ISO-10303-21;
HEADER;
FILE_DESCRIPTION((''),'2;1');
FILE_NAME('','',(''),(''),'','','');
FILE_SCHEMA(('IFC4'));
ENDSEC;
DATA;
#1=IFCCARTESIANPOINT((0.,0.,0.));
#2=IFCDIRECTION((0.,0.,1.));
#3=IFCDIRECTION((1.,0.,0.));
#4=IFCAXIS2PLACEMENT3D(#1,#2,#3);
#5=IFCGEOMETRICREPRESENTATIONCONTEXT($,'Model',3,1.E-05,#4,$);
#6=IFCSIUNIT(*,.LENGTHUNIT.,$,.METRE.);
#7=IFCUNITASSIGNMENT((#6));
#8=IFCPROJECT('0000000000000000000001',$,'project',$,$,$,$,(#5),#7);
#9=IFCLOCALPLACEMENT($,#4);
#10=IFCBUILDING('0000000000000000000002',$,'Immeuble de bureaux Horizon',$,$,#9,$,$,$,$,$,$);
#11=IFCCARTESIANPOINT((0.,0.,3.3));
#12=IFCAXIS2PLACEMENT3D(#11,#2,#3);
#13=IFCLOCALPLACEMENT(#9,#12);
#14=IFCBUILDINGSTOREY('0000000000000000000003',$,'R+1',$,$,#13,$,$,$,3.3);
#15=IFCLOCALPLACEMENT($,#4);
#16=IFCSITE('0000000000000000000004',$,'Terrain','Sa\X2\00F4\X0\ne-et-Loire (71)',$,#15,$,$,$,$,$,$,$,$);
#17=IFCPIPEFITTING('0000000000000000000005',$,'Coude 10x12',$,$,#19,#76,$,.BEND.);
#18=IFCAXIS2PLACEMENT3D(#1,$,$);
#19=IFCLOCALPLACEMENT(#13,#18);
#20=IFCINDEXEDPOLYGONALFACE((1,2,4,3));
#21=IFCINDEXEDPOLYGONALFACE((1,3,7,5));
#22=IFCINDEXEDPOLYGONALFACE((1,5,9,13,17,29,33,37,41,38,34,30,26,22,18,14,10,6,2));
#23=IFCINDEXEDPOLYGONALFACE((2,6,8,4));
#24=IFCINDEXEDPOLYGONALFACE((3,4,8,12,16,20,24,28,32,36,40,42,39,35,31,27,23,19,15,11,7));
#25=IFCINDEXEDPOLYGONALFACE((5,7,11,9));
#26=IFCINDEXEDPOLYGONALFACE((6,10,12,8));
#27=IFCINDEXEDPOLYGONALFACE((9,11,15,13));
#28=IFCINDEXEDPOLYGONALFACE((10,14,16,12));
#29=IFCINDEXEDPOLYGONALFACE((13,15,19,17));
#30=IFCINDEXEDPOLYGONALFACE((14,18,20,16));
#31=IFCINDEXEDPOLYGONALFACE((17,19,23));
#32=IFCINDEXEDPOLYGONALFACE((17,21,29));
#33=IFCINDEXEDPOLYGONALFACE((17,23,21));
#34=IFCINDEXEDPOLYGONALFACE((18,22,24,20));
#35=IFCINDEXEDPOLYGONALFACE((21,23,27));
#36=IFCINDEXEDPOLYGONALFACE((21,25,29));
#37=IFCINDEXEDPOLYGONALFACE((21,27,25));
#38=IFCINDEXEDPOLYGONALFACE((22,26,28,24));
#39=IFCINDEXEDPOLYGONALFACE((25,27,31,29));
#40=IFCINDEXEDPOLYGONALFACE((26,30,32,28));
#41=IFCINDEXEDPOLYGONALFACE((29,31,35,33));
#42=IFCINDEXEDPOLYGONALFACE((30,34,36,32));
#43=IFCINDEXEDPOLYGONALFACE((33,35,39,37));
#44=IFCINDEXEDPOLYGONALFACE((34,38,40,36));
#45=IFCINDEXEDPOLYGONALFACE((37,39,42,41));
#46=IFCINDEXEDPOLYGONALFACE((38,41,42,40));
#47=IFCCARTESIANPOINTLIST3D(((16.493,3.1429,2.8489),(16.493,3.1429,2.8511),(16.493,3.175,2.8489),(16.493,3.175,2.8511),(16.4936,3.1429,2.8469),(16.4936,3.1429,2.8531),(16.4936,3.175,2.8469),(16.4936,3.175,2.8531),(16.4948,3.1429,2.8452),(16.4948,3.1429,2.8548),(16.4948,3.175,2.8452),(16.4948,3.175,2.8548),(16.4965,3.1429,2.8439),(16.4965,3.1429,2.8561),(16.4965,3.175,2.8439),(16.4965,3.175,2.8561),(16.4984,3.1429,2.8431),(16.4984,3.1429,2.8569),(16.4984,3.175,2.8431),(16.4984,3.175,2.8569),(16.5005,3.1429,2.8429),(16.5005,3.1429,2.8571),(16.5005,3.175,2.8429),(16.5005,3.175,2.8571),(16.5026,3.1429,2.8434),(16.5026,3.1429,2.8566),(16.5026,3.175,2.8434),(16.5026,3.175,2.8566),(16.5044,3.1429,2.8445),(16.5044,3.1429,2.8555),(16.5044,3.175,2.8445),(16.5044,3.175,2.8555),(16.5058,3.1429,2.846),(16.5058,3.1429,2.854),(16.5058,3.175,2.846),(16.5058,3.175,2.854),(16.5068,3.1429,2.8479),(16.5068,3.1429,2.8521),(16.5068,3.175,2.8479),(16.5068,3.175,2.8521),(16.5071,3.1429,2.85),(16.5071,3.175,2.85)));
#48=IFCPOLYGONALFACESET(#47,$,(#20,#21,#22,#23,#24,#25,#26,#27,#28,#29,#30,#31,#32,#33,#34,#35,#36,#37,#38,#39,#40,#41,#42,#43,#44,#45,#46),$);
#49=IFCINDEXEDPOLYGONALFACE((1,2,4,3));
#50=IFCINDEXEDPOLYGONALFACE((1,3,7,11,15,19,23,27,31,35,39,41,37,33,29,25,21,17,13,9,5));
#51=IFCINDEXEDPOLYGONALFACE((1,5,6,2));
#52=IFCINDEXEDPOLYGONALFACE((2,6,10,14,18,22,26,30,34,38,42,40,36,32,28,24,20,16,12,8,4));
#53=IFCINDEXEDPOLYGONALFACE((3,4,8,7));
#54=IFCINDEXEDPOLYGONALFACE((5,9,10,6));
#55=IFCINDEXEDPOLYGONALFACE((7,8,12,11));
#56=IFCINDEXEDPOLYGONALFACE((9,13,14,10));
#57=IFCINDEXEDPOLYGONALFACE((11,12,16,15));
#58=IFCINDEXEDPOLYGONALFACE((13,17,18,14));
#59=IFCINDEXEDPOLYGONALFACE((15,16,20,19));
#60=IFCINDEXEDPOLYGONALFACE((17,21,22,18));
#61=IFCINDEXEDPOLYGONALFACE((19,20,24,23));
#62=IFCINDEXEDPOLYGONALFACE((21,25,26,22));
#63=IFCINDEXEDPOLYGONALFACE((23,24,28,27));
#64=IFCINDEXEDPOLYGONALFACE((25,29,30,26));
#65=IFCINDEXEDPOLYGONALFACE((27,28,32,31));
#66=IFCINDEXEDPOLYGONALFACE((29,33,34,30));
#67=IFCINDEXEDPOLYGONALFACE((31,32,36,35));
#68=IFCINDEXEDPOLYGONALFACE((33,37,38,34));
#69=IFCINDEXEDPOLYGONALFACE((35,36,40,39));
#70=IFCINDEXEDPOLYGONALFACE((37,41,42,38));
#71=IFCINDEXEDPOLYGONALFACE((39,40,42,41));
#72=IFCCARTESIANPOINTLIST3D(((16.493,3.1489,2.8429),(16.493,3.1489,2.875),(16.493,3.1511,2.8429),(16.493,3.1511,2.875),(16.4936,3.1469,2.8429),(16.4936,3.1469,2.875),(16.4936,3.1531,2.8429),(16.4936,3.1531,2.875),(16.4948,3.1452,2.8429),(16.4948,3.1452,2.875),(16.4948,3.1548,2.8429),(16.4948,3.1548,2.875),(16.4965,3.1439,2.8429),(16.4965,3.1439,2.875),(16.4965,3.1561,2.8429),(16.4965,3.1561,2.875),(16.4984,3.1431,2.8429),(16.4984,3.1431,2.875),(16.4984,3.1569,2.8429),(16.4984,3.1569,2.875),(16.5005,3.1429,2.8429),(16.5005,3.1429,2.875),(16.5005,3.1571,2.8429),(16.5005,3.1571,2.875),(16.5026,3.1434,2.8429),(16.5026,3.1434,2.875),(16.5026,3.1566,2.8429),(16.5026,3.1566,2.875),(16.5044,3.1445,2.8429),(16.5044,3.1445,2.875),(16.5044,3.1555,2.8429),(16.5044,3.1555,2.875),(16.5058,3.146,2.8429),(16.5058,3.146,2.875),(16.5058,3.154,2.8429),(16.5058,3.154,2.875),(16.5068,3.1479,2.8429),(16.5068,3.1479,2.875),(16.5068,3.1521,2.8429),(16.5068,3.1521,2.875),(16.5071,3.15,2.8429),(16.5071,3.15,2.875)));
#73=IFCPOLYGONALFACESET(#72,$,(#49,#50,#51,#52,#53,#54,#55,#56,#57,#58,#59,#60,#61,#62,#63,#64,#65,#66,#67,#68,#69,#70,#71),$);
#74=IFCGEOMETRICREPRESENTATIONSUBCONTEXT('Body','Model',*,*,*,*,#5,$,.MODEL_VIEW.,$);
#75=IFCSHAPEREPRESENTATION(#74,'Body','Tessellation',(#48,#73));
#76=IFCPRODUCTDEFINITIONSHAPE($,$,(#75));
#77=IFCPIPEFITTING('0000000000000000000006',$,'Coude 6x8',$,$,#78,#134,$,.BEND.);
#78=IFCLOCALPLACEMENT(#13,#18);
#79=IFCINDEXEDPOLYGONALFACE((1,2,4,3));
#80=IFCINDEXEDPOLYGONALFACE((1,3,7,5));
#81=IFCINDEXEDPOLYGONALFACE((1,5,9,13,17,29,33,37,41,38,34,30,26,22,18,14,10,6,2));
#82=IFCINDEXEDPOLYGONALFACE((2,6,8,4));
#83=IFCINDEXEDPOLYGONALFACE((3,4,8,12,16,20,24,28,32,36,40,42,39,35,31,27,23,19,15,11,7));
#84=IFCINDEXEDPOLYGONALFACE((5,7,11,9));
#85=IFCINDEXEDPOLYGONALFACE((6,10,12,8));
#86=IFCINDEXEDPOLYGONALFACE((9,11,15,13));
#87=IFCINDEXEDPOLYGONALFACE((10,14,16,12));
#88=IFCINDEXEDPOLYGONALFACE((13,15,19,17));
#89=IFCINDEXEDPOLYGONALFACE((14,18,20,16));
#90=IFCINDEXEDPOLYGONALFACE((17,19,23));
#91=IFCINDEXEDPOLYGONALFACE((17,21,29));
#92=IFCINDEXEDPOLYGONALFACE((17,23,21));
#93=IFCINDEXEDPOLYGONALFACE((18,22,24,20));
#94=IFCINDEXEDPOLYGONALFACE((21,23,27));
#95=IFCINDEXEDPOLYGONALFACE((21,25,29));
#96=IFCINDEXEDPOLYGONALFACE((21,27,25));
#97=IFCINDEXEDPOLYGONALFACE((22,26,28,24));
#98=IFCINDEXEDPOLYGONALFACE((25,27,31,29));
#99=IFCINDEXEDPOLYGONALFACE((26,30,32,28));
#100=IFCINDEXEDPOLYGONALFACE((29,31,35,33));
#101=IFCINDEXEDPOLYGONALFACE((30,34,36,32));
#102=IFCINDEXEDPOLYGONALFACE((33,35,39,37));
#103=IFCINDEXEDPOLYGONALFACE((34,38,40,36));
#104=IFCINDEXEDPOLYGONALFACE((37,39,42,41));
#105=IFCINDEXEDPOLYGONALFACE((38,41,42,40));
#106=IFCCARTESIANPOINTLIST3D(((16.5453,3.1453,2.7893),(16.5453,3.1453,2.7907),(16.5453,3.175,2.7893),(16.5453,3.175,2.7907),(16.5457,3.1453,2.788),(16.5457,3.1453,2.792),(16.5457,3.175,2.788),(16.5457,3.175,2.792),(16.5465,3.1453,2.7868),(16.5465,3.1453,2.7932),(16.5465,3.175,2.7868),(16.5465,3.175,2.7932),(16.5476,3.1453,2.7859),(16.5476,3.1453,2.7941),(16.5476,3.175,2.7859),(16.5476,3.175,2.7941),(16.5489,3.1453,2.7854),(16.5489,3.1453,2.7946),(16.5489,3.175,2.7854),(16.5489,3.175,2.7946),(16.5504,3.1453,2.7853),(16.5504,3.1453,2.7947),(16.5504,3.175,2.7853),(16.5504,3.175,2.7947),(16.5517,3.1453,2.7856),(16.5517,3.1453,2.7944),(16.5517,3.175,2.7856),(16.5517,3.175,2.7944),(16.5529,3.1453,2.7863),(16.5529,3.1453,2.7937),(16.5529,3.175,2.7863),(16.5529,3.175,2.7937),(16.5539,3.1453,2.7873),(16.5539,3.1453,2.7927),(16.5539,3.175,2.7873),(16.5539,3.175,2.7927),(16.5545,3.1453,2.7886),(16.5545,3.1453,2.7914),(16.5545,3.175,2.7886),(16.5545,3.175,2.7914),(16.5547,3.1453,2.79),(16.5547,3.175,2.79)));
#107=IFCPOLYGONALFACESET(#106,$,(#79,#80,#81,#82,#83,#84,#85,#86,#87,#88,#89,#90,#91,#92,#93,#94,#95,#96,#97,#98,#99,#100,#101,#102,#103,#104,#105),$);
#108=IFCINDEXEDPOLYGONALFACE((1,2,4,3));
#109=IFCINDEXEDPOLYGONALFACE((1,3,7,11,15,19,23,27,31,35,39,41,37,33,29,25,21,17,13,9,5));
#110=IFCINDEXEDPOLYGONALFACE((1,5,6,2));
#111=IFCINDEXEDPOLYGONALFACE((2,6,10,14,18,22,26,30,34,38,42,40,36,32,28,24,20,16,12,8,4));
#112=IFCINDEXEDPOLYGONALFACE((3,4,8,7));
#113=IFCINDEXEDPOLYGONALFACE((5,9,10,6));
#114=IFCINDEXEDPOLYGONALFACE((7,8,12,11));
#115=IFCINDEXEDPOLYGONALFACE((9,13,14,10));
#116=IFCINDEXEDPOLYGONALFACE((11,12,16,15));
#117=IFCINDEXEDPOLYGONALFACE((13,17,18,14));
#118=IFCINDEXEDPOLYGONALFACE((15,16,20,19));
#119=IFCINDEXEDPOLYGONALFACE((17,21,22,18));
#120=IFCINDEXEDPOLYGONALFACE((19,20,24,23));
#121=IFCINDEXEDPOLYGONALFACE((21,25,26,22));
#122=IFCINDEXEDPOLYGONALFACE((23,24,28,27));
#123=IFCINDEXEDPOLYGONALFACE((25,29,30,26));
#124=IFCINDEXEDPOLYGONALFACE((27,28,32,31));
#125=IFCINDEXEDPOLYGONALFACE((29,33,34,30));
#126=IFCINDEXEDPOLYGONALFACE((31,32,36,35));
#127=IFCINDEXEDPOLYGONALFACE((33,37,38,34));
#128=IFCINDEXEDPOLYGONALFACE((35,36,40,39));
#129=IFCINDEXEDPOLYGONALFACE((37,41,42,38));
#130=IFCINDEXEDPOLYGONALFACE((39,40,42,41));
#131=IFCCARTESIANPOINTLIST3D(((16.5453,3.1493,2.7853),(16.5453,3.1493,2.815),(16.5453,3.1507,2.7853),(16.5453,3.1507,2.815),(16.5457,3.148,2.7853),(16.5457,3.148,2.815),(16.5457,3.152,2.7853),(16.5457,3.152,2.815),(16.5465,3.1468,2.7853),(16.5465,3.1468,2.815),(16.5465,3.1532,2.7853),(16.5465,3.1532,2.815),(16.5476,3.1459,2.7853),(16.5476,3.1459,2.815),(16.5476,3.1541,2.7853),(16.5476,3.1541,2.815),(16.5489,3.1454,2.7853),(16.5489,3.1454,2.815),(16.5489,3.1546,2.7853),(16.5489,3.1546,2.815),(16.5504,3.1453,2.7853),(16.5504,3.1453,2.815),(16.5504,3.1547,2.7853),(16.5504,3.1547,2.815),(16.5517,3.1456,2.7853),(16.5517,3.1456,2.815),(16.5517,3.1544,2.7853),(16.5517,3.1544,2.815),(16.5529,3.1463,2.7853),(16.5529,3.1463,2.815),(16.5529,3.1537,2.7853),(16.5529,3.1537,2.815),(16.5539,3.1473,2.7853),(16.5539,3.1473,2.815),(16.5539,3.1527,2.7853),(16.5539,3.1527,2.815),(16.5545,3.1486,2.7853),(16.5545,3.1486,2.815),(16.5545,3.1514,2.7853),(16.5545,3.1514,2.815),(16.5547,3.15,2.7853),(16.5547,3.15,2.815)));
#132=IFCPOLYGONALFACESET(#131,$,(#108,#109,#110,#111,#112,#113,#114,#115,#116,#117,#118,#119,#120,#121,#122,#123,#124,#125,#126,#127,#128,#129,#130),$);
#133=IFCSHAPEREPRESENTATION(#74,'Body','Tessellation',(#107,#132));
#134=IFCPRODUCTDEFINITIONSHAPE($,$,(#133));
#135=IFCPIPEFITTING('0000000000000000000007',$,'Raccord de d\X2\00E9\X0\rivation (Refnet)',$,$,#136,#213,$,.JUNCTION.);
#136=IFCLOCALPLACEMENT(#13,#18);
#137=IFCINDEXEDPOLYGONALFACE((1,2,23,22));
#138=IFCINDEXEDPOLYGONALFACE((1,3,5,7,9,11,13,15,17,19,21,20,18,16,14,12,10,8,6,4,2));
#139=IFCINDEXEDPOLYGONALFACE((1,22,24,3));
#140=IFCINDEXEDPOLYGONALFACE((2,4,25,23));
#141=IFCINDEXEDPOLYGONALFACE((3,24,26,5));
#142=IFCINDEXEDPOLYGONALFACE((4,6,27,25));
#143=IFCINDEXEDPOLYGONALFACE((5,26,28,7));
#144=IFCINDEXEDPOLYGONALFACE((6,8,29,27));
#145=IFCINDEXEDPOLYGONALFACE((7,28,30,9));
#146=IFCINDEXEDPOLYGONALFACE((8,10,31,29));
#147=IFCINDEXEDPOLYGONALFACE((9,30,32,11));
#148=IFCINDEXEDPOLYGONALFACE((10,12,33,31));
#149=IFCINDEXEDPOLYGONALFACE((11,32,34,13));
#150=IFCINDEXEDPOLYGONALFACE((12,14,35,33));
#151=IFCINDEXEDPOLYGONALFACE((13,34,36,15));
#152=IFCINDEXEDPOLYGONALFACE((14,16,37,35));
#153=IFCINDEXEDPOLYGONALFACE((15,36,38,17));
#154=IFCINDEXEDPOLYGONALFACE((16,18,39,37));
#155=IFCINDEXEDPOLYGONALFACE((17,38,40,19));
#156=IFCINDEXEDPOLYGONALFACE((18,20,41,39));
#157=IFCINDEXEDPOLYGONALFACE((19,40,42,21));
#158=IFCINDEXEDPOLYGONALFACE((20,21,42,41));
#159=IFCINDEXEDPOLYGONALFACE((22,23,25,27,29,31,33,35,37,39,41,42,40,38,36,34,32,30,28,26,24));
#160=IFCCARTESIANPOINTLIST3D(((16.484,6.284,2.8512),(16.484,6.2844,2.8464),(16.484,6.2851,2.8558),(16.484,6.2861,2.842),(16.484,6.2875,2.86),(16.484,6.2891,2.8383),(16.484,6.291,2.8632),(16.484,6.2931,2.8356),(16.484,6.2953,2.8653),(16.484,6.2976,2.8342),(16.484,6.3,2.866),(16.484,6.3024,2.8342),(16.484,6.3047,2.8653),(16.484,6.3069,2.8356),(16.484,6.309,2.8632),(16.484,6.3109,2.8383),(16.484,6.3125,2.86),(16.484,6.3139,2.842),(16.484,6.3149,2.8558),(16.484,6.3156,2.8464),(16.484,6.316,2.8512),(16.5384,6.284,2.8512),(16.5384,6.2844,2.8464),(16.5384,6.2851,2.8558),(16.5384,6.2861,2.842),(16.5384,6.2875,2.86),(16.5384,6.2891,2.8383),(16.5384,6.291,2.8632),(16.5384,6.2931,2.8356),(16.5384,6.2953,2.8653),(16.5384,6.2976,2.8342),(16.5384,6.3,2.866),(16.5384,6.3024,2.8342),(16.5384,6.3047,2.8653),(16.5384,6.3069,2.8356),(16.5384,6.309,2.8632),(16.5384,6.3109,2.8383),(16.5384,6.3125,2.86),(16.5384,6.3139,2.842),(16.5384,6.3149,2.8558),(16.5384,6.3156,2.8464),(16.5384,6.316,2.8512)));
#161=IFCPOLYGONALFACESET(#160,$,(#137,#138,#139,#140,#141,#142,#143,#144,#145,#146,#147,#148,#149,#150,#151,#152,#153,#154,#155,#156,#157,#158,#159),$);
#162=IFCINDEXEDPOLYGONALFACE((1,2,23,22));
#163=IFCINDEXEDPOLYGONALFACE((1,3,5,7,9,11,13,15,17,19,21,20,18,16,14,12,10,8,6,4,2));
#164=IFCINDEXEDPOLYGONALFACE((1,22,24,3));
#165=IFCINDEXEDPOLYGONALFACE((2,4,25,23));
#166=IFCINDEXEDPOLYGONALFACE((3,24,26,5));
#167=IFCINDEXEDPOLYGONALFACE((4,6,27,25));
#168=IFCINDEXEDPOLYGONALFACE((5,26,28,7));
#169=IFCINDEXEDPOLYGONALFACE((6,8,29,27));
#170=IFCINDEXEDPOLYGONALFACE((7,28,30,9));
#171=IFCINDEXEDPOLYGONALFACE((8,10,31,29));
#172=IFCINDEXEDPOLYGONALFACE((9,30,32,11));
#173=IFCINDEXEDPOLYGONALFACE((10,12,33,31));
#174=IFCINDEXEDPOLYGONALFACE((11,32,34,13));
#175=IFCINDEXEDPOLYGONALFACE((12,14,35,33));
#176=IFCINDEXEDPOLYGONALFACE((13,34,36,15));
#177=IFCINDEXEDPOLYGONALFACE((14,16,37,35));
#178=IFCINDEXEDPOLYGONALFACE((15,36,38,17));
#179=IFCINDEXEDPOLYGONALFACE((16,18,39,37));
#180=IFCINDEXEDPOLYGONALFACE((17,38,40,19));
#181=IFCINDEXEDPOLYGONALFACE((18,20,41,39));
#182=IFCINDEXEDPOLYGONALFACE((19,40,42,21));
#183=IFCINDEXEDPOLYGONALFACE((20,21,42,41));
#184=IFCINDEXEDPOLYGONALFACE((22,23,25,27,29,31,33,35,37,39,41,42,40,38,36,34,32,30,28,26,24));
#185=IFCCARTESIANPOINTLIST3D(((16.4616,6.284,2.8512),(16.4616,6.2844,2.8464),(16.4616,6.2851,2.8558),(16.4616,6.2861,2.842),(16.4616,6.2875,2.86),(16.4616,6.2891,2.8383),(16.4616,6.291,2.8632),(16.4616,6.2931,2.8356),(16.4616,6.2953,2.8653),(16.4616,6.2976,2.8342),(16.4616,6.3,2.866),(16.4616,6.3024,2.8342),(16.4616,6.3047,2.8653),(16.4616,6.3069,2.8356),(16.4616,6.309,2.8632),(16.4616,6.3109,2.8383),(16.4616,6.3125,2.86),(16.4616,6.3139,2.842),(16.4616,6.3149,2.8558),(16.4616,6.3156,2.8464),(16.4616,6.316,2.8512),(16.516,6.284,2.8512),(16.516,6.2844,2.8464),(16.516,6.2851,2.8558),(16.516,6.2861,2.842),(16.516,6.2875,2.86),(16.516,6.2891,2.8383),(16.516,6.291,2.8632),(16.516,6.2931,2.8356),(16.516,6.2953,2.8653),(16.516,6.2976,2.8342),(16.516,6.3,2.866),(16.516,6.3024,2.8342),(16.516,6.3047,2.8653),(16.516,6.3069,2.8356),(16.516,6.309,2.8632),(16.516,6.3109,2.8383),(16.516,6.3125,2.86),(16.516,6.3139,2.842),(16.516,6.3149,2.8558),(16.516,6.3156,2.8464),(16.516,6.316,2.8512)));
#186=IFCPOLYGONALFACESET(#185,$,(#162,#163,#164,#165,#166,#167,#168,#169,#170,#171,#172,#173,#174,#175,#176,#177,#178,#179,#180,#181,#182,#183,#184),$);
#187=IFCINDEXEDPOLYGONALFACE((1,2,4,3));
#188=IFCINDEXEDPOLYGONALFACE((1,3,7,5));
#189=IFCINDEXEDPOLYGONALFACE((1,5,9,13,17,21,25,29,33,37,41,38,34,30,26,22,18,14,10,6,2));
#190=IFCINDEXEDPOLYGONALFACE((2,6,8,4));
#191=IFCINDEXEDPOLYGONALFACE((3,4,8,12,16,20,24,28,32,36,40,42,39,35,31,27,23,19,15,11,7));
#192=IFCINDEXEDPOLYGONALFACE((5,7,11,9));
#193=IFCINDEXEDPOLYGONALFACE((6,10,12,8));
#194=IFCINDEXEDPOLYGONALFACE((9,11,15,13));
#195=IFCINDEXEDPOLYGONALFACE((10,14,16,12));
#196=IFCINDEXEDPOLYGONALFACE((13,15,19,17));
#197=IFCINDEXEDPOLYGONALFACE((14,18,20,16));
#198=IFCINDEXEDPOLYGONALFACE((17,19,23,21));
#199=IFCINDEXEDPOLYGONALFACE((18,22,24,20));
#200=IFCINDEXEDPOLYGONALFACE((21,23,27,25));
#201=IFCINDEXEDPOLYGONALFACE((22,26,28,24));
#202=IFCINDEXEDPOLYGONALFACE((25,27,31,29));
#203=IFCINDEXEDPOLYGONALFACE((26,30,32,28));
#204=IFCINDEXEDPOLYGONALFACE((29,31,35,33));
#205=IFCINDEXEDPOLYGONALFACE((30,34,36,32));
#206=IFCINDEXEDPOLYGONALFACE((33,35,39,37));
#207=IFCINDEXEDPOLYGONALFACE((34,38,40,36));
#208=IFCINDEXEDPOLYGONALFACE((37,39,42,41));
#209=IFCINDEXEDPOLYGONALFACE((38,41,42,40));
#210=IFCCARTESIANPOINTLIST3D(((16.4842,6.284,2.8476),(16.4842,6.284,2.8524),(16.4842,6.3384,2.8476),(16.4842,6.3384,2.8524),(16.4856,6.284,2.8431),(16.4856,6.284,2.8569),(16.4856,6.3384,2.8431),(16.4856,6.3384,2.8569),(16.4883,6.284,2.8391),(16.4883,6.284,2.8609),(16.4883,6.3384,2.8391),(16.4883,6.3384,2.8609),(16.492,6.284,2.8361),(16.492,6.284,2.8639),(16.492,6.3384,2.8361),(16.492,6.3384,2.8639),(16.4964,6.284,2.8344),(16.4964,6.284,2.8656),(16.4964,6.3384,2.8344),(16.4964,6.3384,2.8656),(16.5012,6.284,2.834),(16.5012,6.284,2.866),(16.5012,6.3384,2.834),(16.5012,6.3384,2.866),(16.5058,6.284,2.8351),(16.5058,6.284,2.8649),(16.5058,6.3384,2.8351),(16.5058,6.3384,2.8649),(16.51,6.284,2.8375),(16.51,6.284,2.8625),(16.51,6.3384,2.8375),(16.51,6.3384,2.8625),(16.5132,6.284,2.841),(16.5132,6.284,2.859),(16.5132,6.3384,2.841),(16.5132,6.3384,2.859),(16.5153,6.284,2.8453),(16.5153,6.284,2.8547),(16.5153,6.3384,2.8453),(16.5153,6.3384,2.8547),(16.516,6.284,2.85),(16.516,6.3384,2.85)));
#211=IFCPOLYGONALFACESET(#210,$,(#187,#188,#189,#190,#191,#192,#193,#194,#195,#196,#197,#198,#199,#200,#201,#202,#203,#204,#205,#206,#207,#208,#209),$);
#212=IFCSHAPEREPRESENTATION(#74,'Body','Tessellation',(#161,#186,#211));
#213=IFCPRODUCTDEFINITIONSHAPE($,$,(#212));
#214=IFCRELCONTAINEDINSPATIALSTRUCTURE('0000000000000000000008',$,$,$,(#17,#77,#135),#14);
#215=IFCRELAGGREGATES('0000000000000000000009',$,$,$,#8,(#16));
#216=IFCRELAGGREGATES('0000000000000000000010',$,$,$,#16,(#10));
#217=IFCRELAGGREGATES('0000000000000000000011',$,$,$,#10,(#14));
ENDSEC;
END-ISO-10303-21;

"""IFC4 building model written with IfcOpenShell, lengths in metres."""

from ifc_helpers import new_model, si_unit, frame, origin_with_axes, place, context, subcontext, project, spatial, circle, extrude, element, save


model = new_model("IFC4")

# Units and contexts
model_context = context("Model", 3, precision=1e-05, world=origin_with_axes())
body_context = subcontext(model_context, "Body", "Model", "MODEL_VIEW")
ifc_project = project(units=[si_unit("LENGTHUNIT", "METRE")], contexts=[model_context])

# Site, building, storey
site_placement = place(None, origin_with_axes())
site = spatial("IfcSite", under=ifc_project, at=site_placement, Name="Terrain", Description="Saône-et-Loire (71)")
building_placement = place(None, origin_with_axes())
building = spatial("IfcBuilding", under=site, at=building_placement, Name="Immeuble de bureaux Horizon")
storey_placement = place(building_placement, frame((0.0, 0.0, 3.3), z_axis=(0.0, 0.0, 1.0), x_axis=(1.0, 0.0, 0.0)))
storey = spatial("IfcBuildingStorey", under=building, at=storey_placement, Name="R+1", Elevation=3.3)

# Pipe fittings
pipe_fitting_1_placement = place(storey_placement, frame((16.5, 3.15, 2.85), z_axis=(0.0, 0.0, 1.0), x_axis=(1.0, 0.0, 0.0)))
element("IfcPipeFitting", 1, at=pipe_fitting_1_placement, inside=storey, Name="Coude 10x12", PredefinedType="BEND", context=body_context, shape_type="SweptSolid", body=[
    extrude(circle(Radius=0.0071), frame((0.0, -0.0071, 0.0), z_axis=(0.0, 1.0, 0.0), x_axis=(1.0, 0.0, 0.0)), (0.0, 0.0, 1.0), 0.0321),
    extrude(circle(Radius=0.0071), frame((0.0, 0.0, -0.0071), z_axis=(0.0, 0.0, 1.0), x_axis=(1.0, 0.0, 0.0)), (0.0, 0.0, 1.0), 0.0321),
])
pipe_fitting_2_placement = place(storey_placement, frame((16.55, 3.15, 2.79), z_axis=(0.0, 0.0, 1.0), x_axis=(1.0, 0.0, 0.0)))
element("IfcPipeFitting", 2, at=pipe_fitting_2_placement, inside=storey, Name="Coude 6x8", PredefinedType="BEND", context=body_context, shape_type="SweptSolid", body=[
    extrude(circle(Radius=0.0047), frame((0.0, -0.0047, 0.0), z_axis=(0.0, 1.0, 0.0), x_axis=(1.0, 0.0, 0.0)), (0.0, 0.0, 1.0), 0.0297),
    extrude(circle(Radius=0.0047), frame((0.0, 0.0, -0.0047), z_axis=(0.0, 0.0, 1.0), x_axis=(1.0, 0.0, 0.0)), (0.0, 0.0, 1.0), 0.0297),
])
pipe_fitting_3_placement = place(storey_placement, frame((16.5, 6.3, 2.85), z_axis=(0.0, 0.0, 1.0), x_axis=(1.0, 0.0, 0.0)))
element("IfcPipeFitting", 3, at=pipe_fitting_3_placement, inside=storey, Name="Raccord de dérivation (Refnet)", PredefinedType="JUNCTION", context=body_context, shape_type="SweptSolid", body=[
    extrude(circle(Radius=0.016), frame((-0.016, 0.0, 0.0), z_axis=(1.0, 0.0, 0.0), x_axis=(0.0, 0.0, 1.0)), (0.0, 0.0, 1.0), 0.0544),
    extrude(circle(Radius=0.016), frame((0.016, 0.0, 0.0), z_axis=(-1.0, 0.0, 0.0), x_axis=(0.0, 0.0, 1.0)), (0.0, 0.0, 1.0), 0.0544),
    extrude(circle(Radius=0.016), frame((0.0, -0.016, 0.0), z_axis=(0.0, 1.0, 0.0), x_axis=(1.0, 0.0, 0.0)), (0.0, 0.0, 1.0), 0.0544),
])

save(model, "model.ifc")
